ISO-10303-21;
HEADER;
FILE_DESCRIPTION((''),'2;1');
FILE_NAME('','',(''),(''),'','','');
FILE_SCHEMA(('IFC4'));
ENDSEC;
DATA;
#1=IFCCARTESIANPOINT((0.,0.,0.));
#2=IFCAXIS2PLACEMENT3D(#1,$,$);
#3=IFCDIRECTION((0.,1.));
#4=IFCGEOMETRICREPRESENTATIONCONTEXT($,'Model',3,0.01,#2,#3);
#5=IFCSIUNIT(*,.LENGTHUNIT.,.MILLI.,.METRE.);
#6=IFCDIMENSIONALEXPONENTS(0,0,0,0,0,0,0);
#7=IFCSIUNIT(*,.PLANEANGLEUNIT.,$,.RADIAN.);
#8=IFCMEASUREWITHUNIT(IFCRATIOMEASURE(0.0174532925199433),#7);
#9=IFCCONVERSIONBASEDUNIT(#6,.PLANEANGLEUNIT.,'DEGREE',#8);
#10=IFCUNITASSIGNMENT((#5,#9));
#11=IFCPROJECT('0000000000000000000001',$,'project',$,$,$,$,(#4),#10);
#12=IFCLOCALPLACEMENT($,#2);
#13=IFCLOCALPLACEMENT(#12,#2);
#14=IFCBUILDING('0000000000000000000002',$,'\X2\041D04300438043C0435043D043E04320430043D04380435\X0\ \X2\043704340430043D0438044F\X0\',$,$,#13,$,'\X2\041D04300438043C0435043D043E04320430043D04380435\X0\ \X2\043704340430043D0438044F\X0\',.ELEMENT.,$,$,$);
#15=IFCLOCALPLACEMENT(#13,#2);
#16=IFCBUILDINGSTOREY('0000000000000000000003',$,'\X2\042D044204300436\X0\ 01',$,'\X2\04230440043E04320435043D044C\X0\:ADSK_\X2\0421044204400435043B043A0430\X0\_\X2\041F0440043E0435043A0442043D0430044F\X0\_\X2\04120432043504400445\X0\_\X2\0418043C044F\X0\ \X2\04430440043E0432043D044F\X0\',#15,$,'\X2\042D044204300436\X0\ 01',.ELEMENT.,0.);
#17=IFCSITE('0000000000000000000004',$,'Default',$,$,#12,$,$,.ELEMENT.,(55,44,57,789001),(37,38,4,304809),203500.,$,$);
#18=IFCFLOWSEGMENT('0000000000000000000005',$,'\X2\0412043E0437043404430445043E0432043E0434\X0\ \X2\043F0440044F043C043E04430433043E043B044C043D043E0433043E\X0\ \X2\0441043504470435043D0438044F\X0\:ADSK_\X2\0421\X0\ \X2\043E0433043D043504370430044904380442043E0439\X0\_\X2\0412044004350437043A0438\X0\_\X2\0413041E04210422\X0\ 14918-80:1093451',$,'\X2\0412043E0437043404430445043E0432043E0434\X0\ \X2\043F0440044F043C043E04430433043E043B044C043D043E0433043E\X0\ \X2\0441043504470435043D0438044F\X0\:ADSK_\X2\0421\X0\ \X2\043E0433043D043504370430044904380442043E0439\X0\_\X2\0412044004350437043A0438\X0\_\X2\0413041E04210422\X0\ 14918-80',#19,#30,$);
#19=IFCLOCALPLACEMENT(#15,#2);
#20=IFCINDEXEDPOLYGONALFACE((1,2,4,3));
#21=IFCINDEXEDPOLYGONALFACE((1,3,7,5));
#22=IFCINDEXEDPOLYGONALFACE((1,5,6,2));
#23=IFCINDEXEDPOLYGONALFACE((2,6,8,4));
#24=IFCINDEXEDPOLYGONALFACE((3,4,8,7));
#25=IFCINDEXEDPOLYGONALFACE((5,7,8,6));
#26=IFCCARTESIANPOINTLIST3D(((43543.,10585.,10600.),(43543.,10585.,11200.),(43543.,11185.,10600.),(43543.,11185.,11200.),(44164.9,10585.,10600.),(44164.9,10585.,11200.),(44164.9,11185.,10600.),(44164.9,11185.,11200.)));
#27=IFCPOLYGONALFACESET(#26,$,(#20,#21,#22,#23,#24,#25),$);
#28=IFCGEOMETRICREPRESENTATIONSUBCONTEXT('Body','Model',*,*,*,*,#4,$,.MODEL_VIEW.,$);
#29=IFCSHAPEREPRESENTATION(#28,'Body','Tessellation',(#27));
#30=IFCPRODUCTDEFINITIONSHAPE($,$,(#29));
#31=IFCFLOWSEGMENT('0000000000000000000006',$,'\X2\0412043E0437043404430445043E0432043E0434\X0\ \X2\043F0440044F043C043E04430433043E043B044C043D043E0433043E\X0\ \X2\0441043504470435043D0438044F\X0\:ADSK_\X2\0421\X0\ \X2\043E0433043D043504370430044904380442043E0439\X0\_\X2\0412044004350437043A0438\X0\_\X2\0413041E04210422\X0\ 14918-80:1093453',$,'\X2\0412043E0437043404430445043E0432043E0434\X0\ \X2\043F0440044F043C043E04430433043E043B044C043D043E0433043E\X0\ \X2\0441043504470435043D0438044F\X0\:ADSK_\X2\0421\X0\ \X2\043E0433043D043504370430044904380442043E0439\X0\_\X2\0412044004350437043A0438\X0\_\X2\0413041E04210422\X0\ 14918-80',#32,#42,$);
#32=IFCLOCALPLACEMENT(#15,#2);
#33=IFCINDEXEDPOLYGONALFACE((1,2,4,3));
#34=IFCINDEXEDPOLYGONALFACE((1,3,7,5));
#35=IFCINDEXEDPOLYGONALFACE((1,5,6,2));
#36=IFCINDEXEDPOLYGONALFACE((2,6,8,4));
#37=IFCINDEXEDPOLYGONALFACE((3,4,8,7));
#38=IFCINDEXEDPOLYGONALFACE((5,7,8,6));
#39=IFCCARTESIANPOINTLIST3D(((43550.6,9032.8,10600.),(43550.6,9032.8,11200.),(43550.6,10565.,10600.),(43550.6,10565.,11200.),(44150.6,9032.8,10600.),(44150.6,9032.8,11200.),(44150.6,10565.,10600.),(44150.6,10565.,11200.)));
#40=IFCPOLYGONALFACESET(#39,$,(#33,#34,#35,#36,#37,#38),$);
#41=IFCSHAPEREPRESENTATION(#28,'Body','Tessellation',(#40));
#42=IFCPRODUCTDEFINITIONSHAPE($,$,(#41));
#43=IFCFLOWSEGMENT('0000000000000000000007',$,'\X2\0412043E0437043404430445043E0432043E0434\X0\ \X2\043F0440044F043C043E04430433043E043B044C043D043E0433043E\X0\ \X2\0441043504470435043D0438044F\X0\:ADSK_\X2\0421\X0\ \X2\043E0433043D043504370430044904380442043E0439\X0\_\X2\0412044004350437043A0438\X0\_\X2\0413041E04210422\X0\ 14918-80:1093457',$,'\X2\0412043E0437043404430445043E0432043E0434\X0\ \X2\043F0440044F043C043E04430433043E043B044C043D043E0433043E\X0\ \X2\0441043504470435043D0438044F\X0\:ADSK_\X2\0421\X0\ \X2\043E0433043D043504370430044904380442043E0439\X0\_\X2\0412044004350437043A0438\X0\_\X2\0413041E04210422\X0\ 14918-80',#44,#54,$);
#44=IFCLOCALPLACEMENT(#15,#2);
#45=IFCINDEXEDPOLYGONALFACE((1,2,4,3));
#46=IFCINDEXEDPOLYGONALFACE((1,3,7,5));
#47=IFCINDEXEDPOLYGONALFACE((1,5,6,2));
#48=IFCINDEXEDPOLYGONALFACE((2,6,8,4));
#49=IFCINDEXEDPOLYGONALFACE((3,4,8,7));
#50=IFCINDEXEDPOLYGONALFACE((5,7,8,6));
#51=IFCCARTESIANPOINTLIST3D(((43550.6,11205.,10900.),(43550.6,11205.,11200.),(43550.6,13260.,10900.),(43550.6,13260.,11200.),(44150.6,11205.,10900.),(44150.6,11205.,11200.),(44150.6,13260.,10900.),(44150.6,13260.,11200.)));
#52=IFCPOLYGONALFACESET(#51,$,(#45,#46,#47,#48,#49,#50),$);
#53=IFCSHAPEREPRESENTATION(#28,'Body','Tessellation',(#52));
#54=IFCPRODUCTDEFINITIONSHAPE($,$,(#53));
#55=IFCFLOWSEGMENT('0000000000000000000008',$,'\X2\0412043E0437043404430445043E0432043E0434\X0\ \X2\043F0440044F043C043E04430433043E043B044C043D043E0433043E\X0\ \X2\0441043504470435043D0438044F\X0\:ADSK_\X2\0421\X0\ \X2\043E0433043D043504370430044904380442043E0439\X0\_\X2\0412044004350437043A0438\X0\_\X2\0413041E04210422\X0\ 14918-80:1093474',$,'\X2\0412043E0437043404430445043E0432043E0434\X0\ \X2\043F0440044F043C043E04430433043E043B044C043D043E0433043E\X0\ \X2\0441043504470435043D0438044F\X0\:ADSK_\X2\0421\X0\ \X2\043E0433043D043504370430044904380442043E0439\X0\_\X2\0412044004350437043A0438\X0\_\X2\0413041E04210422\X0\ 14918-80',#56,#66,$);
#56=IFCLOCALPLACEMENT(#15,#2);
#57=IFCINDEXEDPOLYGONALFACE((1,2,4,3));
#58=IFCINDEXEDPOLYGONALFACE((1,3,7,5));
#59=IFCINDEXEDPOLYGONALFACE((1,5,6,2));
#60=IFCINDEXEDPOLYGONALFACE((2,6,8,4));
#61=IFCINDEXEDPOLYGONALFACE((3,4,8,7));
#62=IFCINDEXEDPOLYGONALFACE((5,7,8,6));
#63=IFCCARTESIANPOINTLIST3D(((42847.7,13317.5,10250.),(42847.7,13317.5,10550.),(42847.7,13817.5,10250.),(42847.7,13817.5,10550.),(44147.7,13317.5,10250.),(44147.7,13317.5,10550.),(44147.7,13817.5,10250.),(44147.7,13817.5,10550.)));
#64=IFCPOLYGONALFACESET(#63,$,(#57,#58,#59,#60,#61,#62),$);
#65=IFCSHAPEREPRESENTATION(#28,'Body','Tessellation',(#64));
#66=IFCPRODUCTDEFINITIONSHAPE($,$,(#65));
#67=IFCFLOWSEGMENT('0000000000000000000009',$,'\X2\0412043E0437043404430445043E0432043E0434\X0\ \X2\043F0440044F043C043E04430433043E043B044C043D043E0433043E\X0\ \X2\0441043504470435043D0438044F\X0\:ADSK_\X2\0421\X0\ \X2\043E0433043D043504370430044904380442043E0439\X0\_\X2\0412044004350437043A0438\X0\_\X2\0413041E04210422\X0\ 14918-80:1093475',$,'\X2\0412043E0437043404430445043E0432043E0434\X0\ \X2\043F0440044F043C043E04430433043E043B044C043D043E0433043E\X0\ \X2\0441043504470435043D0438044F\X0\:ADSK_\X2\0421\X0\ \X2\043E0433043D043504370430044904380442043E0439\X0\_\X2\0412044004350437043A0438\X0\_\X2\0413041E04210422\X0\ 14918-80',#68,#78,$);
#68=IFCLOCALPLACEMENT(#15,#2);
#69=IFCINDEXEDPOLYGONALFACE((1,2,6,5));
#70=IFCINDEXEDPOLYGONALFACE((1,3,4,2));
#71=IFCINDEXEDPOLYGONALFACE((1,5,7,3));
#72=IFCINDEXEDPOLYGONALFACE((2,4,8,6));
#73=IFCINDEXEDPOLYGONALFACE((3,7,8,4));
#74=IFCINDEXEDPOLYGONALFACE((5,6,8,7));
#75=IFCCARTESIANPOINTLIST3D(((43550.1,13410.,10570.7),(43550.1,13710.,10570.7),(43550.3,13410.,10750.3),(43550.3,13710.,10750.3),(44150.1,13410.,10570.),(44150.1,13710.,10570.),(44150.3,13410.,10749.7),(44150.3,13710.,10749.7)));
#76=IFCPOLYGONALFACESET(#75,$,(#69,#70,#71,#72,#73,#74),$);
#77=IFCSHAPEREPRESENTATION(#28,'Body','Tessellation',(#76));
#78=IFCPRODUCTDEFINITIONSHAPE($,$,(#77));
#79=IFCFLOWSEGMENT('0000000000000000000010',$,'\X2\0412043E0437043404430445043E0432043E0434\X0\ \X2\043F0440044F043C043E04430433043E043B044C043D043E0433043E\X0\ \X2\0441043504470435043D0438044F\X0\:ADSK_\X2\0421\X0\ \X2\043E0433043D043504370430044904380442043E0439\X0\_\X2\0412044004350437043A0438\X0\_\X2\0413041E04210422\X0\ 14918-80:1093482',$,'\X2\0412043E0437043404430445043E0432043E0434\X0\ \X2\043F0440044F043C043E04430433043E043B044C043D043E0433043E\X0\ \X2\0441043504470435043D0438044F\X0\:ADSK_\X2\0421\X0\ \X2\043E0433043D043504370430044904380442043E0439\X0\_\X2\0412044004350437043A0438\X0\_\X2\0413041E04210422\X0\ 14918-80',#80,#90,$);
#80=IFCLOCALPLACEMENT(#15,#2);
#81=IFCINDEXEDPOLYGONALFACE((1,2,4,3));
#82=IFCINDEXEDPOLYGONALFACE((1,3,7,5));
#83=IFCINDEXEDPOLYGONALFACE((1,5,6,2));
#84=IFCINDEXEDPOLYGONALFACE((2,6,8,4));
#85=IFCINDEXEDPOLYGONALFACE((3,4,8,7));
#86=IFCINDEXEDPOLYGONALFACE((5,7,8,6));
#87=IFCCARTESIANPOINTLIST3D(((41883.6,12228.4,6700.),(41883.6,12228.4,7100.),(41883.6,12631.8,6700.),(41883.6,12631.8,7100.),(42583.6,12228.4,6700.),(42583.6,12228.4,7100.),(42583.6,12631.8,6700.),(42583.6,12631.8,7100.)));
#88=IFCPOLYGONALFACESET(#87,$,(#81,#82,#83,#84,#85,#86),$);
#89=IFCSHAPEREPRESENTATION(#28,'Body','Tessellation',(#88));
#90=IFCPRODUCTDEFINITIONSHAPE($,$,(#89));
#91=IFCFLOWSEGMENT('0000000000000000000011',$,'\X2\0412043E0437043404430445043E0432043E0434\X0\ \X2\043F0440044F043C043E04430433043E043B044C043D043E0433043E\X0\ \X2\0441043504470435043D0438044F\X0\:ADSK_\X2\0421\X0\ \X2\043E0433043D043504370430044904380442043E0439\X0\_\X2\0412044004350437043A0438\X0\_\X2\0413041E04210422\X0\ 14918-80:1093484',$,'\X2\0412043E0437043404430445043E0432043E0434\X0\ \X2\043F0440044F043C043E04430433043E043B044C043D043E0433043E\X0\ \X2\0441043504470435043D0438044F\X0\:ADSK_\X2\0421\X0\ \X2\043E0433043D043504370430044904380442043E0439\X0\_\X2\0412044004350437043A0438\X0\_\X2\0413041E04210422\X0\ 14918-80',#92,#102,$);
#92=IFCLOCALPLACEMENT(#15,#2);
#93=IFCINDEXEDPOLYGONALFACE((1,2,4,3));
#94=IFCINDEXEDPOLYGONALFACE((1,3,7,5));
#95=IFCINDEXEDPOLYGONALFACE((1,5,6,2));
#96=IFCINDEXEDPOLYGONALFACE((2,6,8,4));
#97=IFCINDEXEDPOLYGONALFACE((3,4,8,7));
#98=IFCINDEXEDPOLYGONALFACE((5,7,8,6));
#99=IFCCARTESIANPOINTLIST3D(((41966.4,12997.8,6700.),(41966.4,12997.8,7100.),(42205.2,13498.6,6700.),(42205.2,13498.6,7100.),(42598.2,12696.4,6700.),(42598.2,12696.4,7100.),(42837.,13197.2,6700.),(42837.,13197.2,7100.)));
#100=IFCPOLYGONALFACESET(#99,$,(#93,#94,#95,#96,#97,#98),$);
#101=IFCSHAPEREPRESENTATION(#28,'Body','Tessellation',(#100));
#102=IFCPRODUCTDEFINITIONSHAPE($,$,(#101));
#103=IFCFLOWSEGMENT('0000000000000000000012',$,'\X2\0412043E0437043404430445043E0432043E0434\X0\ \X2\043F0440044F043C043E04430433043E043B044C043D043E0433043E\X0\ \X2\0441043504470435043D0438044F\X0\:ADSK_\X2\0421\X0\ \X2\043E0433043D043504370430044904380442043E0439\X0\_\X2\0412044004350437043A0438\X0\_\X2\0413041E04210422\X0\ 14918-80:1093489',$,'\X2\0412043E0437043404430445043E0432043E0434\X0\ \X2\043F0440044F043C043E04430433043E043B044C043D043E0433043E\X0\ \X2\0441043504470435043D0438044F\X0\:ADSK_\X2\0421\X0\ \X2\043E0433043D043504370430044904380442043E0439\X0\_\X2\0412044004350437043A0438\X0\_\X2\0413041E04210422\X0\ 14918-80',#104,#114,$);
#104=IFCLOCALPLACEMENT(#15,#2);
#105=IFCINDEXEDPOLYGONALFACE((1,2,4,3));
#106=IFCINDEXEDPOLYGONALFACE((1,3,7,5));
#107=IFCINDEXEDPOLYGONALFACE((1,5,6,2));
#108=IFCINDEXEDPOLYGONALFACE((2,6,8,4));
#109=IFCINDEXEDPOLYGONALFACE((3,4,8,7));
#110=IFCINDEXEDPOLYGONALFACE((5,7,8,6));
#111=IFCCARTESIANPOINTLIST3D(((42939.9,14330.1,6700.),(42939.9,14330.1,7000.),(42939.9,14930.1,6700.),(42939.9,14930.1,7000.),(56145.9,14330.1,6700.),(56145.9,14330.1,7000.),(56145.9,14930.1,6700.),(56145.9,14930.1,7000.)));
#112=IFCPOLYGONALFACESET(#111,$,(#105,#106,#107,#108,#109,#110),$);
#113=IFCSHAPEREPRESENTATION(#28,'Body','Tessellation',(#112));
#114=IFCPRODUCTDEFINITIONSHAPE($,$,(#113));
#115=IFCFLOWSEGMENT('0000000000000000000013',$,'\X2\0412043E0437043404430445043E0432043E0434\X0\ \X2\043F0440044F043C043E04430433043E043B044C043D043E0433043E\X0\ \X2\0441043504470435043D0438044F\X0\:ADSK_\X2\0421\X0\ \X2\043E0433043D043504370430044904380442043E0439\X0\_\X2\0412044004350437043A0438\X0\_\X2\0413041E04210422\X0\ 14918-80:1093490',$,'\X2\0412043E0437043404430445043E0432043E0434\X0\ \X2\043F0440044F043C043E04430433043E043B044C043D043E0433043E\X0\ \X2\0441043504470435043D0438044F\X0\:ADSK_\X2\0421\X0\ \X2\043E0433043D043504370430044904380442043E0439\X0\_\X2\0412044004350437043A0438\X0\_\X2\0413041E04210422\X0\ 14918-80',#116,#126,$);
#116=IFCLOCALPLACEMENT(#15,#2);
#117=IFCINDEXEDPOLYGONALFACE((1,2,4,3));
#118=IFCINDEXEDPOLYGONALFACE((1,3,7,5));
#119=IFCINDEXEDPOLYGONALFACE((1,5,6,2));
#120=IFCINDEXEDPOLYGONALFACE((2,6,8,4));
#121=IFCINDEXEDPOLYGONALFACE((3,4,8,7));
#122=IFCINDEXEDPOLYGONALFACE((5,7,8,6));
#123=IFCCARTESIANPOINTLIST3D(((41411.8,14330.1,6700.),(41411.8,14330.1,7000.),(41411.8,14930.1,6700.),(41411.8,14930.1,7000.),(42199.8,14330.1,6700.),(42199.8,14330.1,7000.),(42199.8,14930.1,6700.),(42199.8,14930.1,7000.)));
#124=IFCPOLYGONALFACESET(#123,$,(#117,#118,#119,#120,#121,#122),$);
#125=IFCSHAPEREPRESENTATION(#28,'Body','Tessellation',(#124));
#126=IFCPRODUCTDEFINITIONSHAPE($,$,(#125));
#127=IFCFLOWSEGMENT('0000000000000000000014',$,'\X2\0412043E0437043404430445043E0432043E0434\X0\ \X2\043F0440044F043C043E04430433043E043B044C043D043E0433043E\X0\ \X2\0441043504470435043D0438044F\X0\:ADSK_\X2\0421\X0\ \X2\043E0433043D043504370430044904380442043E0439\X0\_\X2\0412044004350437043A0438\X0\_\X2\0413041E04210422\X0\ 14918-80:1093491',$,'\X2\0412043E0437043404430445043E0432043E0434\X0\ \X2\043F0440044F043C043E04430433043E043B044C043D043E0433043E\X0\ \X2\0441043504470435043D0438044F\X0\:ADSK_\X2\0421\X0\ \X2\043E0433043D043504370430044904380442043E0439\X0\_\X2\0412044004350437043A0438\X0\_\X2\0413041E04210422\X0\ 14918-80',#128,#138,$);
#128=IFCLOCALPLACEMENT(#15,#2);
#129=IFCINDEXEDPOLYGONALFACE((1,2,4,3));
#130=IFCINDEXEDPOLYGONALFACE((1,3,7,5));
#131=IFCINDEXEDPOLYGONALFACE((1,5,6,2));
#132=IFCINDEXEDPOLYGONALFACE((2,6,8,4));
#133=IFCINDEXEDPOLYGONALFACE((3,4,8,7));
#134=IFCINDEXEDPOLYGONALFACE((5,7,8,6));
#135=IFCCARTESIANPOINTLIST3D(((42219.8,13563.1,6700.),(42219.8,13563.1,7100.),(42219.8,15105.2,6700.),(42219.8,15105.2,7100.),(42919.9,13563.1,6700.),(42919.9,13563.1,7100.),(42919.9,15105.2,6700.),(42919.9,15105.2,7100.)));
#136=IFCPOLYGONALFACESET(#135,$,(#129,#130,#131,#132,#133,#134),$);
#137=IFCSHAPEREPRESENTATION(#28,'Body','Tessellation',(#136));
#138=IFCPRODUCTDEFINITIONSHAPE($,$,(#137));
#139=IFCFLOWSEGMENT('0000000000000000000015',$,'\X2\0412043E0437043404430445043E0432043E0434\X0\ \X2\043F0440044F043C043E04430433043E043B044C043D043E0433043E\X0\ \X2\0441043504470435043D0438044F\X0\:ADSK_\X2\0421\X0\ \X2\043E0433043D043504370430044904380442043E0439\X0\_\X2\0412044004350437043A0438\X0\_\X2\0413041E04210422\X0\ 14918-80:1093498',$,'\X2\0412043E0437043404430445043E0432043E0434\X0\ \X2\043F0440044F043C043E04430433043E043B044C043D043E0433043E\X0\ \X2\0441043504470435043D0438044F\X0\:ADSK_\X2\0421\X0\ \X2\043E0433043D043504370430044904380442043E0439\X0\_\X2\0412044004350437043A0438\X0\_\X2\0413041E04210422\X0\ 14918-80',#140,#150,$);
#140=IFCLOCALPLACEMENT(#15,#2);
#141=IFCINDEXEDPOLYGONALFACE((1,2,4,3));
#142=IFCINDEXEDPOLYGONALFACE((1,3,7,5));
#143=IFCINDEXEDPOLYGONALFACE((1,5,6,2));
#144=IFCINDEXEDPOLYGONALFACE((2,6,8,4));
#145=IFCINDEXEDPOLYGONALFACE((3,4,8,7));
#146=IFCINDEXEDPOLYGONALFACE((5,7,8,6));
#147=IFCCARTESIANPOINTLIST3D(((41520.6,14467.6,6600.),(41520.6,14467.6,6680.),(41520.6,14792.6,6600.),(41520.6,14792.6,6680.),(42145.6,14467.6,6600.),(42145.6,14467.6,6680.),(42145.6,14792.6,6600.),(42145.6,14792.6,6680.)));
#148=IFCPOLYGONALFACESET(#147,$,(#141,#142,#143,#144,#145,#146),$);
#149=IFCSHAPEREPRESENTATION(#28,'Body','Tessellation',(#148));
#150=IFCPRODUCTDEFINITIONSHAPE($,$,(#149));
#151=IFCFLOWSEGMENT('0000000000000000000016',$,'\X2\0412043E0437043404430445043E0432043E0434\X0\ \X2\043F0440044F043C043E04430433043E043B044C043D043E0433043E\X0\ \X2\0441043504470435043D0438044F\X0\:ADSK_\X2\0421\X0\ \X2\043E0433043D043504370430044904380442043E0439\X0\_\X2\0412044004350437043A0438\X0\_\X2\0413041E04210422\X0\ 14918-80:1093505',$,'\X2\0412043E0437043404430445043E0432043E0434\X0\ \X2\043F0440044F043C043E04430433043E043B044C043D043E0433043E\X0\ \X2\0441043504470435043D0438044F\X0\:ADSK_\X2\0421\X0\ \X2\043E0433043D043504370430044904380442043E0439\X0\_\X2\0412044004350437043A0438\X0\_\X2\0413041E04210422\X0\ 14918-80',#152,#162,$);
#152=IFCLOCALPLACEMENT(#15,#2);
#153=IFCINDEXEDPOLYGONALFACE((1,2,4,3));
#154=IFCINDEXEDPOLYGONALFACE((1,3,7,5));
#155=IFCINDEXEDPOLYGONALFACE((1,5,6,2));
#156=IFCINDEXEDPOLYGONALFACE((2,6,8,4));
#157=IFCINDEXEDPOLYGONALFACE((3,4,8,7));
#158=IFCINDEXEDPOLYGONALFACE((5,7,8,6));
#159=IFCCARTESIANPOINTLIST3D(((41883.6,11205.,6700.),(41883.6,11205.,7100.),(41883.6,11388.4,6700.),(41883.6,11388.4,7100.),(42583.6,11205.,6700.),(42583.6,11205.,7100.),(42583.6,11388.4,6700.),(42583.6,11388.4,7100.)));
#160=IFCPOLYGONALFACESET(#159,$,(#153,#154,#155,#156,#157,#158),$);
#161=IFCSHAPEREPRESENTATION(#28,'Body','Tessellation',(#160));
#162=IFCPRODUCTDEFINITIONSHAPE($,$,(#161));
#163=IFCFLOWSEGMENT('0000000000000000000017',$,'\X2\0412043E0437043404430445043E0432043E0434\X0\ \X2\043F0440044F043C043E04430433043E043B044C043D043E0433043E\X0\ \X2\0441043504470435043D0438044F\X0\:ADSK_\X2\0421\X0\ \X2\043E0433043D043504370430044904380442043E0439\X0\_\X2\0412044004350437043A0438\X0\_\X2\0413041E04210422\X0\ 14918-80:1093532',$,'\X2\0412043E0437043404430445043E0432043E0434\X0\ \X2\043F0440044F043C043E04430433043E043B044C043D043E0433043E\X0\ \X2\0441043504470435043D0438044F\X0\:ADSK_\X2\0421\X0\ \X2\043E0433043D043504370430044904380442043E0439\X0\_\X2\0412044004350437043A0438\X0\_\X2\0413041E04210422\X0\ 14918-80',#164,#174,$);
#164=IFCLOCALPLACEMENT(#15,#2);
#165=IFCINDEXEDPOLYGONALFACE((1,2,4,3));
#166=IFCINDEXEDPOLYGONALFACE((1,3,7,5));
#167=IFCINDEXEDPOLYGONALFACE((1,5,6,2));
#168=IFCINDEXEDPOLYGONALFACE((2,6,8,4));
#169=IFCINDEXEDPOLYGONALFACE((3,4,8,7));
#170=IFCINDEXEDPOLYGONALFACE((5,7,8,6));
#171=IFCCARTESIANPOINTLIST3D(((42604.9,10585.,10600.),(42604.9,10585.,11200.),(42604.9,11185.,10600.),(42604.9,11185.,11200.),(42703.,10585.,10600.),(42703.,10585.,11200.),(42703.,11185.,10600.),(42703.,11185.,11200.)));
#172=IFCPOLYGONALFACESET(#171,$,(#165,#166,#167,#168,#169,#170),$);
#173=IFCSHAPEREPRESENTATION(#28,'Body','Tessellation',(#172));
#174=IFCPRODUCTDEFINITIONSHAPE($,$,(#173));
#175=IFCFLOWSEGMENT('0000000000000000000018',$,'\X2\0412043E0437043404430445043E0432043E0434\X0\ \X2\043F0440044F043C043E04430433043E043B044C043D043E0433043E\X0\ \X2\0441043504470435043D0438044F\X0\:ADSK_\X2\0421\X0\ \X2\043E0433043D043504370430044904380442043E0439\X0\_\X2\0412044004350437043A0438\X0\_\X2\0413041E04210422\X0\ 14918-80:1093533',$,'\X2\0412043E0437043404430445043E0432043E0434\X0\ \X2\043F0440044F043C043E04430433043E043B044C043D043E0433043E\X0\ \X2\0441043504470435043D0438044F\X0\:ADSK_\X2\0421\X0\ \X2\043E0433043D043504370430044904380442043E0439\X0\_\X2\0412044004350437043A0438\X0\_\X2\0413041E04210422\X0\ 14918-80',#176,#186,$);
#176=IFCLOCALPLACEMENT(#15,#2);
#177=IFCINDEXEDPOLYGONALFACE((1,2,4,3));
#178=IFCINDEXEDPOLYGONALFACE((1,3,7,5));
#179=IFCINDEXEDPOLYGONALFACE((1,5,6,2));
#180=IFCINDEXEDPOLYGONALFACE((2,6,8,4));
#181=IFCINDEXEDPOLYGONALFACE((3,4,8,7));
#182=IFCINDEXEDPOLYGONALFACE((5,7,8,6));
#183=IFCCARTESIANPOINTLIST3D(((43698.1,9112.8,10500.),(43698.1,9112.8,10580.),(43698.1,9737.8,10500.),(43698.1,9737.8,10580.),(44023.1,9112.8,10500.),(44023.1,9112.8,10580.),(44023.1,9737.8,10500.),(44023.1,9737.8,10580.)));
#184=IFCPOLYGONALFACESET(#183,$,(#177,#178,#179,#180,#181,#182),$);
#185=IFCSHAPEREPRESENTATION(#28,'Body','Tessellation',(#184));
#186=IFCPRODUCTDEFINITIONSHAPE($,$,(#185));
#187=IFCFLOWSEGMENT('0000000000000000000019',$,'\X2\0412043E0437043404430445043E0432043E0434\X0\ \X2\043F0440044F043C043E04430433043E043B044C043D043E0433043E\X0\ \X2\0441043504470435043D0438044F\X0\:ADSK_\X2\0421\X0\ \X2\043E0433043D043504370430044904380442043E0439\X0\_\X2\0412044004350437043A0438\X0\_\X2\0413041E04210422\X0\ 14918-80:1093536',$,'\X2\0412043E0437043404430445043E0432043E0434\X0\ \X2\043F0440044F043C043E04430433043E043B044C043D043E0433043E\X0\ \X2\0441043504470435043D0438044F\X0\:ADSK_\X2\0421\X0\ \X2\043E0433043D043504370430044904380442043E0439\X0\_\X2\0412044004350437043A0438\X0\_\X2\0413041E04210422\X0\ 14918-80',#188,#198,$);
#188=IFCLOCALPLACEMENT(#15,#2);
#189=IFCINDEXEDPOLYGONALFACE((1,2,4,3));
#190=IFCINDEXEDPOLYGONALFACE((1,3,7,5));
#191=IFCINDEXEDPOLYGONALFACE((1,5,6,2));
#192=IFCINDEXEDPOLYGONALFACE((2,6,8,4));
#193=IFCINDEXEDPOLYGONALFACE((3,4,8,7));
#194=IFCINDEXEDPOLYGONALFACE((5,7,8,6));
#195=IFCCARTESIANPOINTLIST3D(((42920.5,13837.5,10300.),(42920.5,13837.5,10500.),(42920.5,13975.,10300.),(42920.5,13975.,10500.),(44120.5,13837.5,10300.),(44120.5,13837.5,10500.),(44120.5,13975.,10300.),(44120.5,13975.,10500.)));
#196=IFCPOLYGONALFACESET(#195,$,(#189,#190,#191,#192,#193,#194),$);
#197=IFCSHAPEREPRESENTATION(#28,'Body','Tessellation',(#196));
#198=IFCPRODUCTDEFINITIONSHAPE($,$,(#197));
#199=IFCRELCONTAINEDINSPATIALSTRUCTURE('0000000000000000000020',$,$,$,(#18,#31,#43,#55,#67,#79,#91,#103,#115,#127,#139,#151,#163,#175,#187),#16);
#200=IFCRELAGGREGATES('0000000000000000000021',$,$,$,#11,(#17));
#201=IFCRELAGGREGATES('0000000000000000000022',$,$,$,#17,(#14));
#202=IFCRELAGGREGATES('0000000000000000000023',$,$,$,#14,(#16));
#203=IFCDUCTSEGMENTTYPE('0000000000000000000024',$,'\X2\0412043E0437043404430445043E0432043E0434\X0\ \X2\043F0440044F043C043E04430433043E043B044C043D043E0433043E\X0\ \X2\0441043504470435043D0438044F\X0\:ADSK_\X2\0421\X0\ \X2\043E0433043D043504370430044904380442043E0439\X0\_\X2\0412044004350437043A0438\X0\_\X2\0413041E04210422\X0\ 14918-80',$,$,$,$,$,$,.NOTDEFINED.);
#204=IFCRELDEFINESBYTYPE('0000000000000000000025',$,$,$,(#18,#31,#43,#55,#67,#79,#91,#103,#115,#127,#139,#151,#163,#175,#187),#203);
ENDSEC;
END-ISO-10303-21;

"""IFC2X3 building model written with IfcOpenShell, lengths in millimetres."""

from ifc_helpers import new_model, entity, si_unit, converted_unit, direction, frame, origin, origin_2d_with_axis, place, context, subcontext, project, spatial, rectangle, extrude, type_object, element, save


model = new_model("IFC2X3")

# Units and contexts
model_context = context("Model", 3, precision=0.01, world=origin(), true_north=direction((0.0, 1.0)))
body_context = subcontext(model_context, "Body", "Model", "MODEL_VIEW")
ifc_project = project(units=[si_unit("LENGTHUNIT", "METRE", prefix="MILLI"), converted_unit("PLANEANGLEUNIT", "DEGREE", entity("IfcRatioMeasure", 0.0174532925199433), si_unit("PLANEANGLEUNIT", "RADIAN"), dimensions=[0, 0, 0, 0, 0, 0, 0])], contexts=[model_context])

# Site, building, storey
site_placement = place(None, origin())
site = spatial("IfcSite", under=ifc_project, at=site_placement, Name="Default", CompositionType="ELEMENT", RefLatitude=(55, 44, 57, 789001), RefLongitude=(37, 38, 4, 304809), RefElevation=203500.0)
building_placement = place(site_placement, origin())
building = spatial("IfcBuilding", under=site, at=building_placement, Name="Наименование здания", LongName="Наименование здания", CompositionType="ELEMENT")
storey_placement = place(building_placement, origin())
storey = spatial("IfcBuildingStorey", under=building, at=storey_placement, Name="Этаж 01", ObjectType="Уровень:ADSK_Стрелка_Проектная_Вверх_Имя уровня", LongName="Этаж 01", CompositionType="ELEMENT", Elevation=0.0)

# Flow segments
duct_segment_type = type_object("IfcDuctSegmentType", Name="Воздуховод прямоугольного сечения:ADSK_С огнезащитой_Врезки_ГОСТ 14918-80", PredefinedType="NOTDEFINED")
flow_segment_1_placement = place(storey_placement, frame((43543.0, 10585.0, 10600.0)))
element("IfcFlowSegment", 1, at=flow_segment_1_placement, inside=storey, type_object=duct_segment_type, Name="Воздуховод прямоугольного сечения:ADSK_С огнезащитой_Врезки_ГОСТ 14918-80:1093451", ObjectType="Воздуховод прямоугольного сечения:ADSK_С огнезащитой_Врезки_ГОСТ 14918-80", context=body_context, shape_type="SweptSolid", body=[
    extrude(rectangle(XDim=621.9, YDim=600.0, at=origin_2d_with_axis()), frame((310.9, 300.0, 0.0)), (0.0, 0.0, 1.0), 600.0),
])
flow_segment_2_placement = place(storey_placement, frame((43550.6, 9032.8, 10600.0)))
element("IfcFlowSegment", 2, at=flow_segment_2_placement, inside=storey, type_object=duct_segment_type, Name="Воздуховод прямоугольного сечения:ADSK_С огнезащитой_Врезки_ГОСТ 14918-80:1093453", ObjectType="Воздуховод прямоугольного сечения:ADSK_С огнезащитой_Врезки_ГОСТ 14918-80", context=body_context, shape_type="SweptSolid", body=[
    extrude(rectangle(XDim=1532.2, YDim=600.0, at=origin_2d_with_axis()), frame((300.0, 766.1, 0.0), z_axis=(0.0, 0.0, 1.0), x_axis=(0.0, 1.0, 0.0)), (0.0, 0.0, 1.0), 600.0),
])
flow_segment_3_placement = place(storey_placement, frame((43550.6, 11205.0, 10900.0)))
element("IfcFlowSegment", 3, at=flow_segment_3_placement, inside=storey, type_object=duct_segment_type, Name="Воздуховод прямоугольного сечения:ADSK_С огнезащитой_Врезки_ГОСТ 14918-80:1093457", ObjectType="Воздуховод прямоугольного сечения:ADSK_С огнезащитой_Врезки_ГОСТ 14918-80", context=body_context, shape_type="SweptSolid", body=[
    extrude(rectangle(XDim=2055.0, YDim=600.0, at=origin_2d_with_axis()), frame((300.0, 1027.5, 0.0), z_axis=(0.0, 0.0, 1.0), x_axis=(0.0, 1.0, 0.0)), (0.0, 0.0, 1.0), 300.0),
])
flow_segment_4_placement = place(storey_placement, frame((42847.7, 13317.5, 10250.0)))
element("IfcFlowSegment", 4, at=flow_segment_4_placement, inside=storey, type_object=duct_segment_type, Name="Воздуховод прямоугольного сечения:ADSK_С огнезащитой_Врезки_ГОСТ 14918-80:1093474", ObjectType="Воздуховод прямоугольного сечения:ADSK_С огнезащитой_Врезки_ГОСТ 14918-80", context=body_context, shape_type="SweptSolid", body=[
    extrude(rectangle(XDim=1300.0, YDim=500.0, at=origin_2d_with_axis()), frame((650.0, 250.0, 0.0), z_axis=(0.0, 0.0, 1.0), x_axis=(-1.0, 0.0, 0.0)), (0.0, 0.0, 1.0), 300.0),
])
flow_segment_5_placement = place(storey_placement, frame((43550.1, 13410.0, 10570.0)))
element("IfcFlowSegment", 5, at=flow_segment_5_placement, inside=storey, type_object=duct_segment_type, Name="Воздуховод прямоугольного сечения:ADSK_С огнезащитой_Врезки_ГОСТ 14918-80:1093475", ObjectType="Воздуховод прямоугольного сечения:ADSK_С огнезащитой_Врезки_ГОСТ 14918-80", context=body_context, shape_type="SweptSolid", body=[
    extrude(rectangle(XDim=600.0, YDim=300.0, at=origin_2d_with_axis()), frame((300.0, 150.0, 0.3), z_axis=(0.0011, 0.0, 0.999999), x_axis=(0.999999, 0.0, -0.0011)), (0.0, 0.0, 1.0), 179.7),
])
flow_segment_6_placement = place(storey_placement, frame((41883.6, 12228.4, 6700.0)))
element("IfcFlowSegment", 6, at=flow_segment_6_placement, inside=storey, type_object=duct_segment_type, Name="Воздуховод прямоугольного сечения:ADSK_С огнезащитой_Врезки_ГОСТ 14918-80:1093482", ObjectType="Воздуховод прямоугольного сечения:ADSK_С огнезащитой_Врезки_ГОСТ 14918-80", context=body_context, shape_type="SweptSolid", body=[
    extrude(rectangle(XDim=403.4, YDim=700.0, at=origin_2d_with_axis()), frame((350.0, 201.7, 0.0), z_axis=(0.0, 0.0, 1.0), x_axis=(0.0, 1.0, 0.0)), (0.0, 0.0, 1.0), 400.0),
])
flow_segment_7_placement = place(storey_placement, frame((41966.4, 12696.4, 6700.0)))
element("IfcFlowSegment", 7, at=flow_segment_7_placement, inside=storey, type_object=duct_segment_type, Name="Воздуховод прямоугольного сечения:ADSK_С огнезащитой_Врезки_ГОСТ 14918-80:1093484", ObjectType="Воздуховод прямоугольного сечения:ADSK_С огнезащитой_Врезки_ГОСТ 14918-80", context=body_context, shape_type="SweptSolid", body=[
    extrude(rectangle(XDim=554.8, YDim=700.0, at=origin_2d_with_axis()), frame((435.3, 401.1, 0.0), z_axis=(0.0, 0.0, 1.0), x_axis=(0.430524, 0.902579, 0.0)), (0.0, 0.0, 1.0), 400.0),
])
flow_segment_8_placement = place(storey_placement, frame((42939.8, 14330.1, 6700.0)))
element("IfcFlowSegment", 8, at=flow_segment_8_placement, inside=storey, type_object=duct_segment_type, Name="Воздуховод прямоугольного сечения:ADSK_С огнезащитой_Врезки_ГОСТ 14918-80:1093489", ObjectType="Воздуховод прямоугольного сечения:ADSK_С огнезащитой_Врезки_ГОСТ 14918-80", context=body_context, shape_type="SweptSolid", body=[
    extrude(rectangle(XDim=13206.1, YDim=600.0, at=origin_2d_with_axis()), frame((6603.0, 300.0, 0.0), z_axis=(0.0, 0.0, 1.0), x_axis=(-1.0, 0.0, 0.0)), (0.0, 0.0, 1.0), 300.0),
])
flow_segment_9_placement = place(storey_placement, frame((41411.8, 14330.1, 6700.0)))
element("IfcFlowSegment", 9, at=flow_segment_9_placement, inside=storey, type_object=duct_segment_type, Name="Воздуховод прямоугольного сечения:ADSK_С огнезащитой_Врезки_ГОСТ 14918-80:1093490", ObjectType="Воздуховод прямоугольного сечения:ADSK_С огнезащитой_Врезки_ГОСТ 14918-80", context=body_context, shape_type="SweptSolid", body=[
    extrude(rectangle(XDim=788.1, YDim=600.0, at=origin_2d_with_axis()), frame((394.0, 300.0, 0.0)), (0.0, 0.0, 1.0), 300.0),
])
flow_segment_10_placement = place(storey_placement, frame((42219.8, 13563.1, 6700.0)))
element("IfcFlowSegment", 10, at=flow_segment_10_placement, inside=storey, type_object=duct_segment_type, Name="Воздуховод прямоугольного сечения:ADSK_С огнезащитой_Врезки_ГОСТ 14918-80:1093491", ObjectType="Воздуховод прямоугольного сечения:ADSK_С огнезащитой_Врезки_ГОСТ 14918-80", context=body_context, shape_type="SweptSolid", body=[
    extrude(rectangle(XDim=1542.1, YDim=700.0, at=origin_2d_with_axis()), frame((350.0, 771.0, 0.0), z_axis=(0.0, 0.0, 1.0), x_axis=(0.0, 1.0, 0.0)), (0.0, 0.0, 1.0), 400.0),
])
flow_segment_11_placement = place(storey_placement, frame((41520.6, 14467.6, 6600.0)))
element("IfcFlowSegment", 11, at=flow_segment_11_placement, inside=storey, type_object=duct_segment_type, Name="Воздуховод прямоугольного сечения:ADSK_С огнезащитой_Врезки_ГОСТ 14918-80:1093498", ObjectType="Воздуховод прямоугольного сечения:ADSK_С огнезащитой_Врезки_ГОСТ 14918-80", context=body_context, shape_type="SweptSolid", body=[
    extrude(rectangle(XDim=625.0, YDim=325.0, at=origin_2d_with_axis()), frame((312.5, 162.5, 0.0), z_axis=(0.0, 0.0, 1.0), x_axis=(-1.0, 0.0, 0.0)), (0.0, 0.0, 1.0), 80.0),
])
flow_segment_12_placement = place(storey_placement, frame((41883.6, 11205.0, 6700.0)))
element("IfcFlowSegment", 12, at=flow_segment_12_placement, inside=storey, type_object=duct_segment_type, Name="Воздуховод прямоугольного сечения:ADSK_С огнезащитой_Врезки_ГОСТ 14918-80:1093505", ObjectType="Воздуховод прямоугольного сечения:ADSK_С огнезащитой_Врезки_ГОСТ 14918-80", context=body_context, shape_type="SweptSolid", body=[
    extrude(rectangle(XDim=183.4, YDim=700.0, at=origin_2d_with_axis()), frame((350.0, 91.7, 0.0), z_axis=(0.0, 0.0, 1.0), x_axis=(0.0, 1.0, 0.0)), (0.0, 0.0, 1.0), 400.0),
])
flow_segment_13_placement = place(storey_placement, frame((42604.9, 10585.0, 10600.0)))
element("IfcFlowSegment", 13, at=flow_segment_13_placement, inside=storey, type_object=duct_segment_type, Name="Воздуховод прямоугольного сечения:ADSK_С огнезащитой_Врезки_ГОСТ 14918-80:1093532", ObjectType="Воздуховод прямоугольного сечения:ADSK_С огнезащитой_Врезки_ГОСТ 14918-80", context=body_context, shape_type="SweptSolid", body=[
    extrude(rectangle(XDim=98.1, YDim=600.0, at=origin_2d_with_axis()), frame((49.0, 300.0, 0.0)), (0.0, 0.0, 1.0), 600.0),
])
flow_segment_14_placement = place(storey_placement, frame((43698.1, 9112.8, 10500.0)))
element("IfcFlowSegment", 14, at=flow_segment_14_placement, inside=storey, type_object=duct_segment_type, Name="Воздуховод прямоугольного сечения:ADSK_С огнезащитой_Врезки_ГОСТ 14918-80:1093533", ObjectType="Воздуховод прямоугольного сечения:ADSK_С огнезащитой_Врезки_ГОСТ 14918-80", context=body_context, shape_type="SweptSolid", body=[
    extrude(rectangle(XDim=325.0, YDim=625.0, at=origin_2d_with_axis()), frame((162.5, 312.5, 0.0), z_axis=(0.0, 0.0, 1.0), x_axis=(-1.0, 0.0, 0.0)), (0.0, 0.0, 1.0), 80.0),
])
flow_segment_15_placement = place(storey_placement, frame((42920.5, 13837.5, 10300.0)))
element("IfcFlowSegment", 15, at=flow_segment_15_placement, inside=storey, type_object=duct_segment_type, Name="Воздуховод прямоугольного сечения:ADSK_С огнезащитой_Врезки_ГОСТ 14918-80:1093536", ObjectType="Воздуховод прямоугольного сечения:ADSK_С огнезащитой_Врезки_ГОСТ 14918-80", context=body_context, shape_type="SweptSolid", body=[
    extrude(rectangle(XDim=137.5, YDim=1200.0, at=origin_2d_with_axis()), frame((600.0, 68.8, 0.0), z_axis=(0.0, 0.0, 1.0), x_axis=(0.0, -1.0, 0.0)), (0.0, 0.0, 1.0), 200.0),
])

save(model, "model.ifc")
